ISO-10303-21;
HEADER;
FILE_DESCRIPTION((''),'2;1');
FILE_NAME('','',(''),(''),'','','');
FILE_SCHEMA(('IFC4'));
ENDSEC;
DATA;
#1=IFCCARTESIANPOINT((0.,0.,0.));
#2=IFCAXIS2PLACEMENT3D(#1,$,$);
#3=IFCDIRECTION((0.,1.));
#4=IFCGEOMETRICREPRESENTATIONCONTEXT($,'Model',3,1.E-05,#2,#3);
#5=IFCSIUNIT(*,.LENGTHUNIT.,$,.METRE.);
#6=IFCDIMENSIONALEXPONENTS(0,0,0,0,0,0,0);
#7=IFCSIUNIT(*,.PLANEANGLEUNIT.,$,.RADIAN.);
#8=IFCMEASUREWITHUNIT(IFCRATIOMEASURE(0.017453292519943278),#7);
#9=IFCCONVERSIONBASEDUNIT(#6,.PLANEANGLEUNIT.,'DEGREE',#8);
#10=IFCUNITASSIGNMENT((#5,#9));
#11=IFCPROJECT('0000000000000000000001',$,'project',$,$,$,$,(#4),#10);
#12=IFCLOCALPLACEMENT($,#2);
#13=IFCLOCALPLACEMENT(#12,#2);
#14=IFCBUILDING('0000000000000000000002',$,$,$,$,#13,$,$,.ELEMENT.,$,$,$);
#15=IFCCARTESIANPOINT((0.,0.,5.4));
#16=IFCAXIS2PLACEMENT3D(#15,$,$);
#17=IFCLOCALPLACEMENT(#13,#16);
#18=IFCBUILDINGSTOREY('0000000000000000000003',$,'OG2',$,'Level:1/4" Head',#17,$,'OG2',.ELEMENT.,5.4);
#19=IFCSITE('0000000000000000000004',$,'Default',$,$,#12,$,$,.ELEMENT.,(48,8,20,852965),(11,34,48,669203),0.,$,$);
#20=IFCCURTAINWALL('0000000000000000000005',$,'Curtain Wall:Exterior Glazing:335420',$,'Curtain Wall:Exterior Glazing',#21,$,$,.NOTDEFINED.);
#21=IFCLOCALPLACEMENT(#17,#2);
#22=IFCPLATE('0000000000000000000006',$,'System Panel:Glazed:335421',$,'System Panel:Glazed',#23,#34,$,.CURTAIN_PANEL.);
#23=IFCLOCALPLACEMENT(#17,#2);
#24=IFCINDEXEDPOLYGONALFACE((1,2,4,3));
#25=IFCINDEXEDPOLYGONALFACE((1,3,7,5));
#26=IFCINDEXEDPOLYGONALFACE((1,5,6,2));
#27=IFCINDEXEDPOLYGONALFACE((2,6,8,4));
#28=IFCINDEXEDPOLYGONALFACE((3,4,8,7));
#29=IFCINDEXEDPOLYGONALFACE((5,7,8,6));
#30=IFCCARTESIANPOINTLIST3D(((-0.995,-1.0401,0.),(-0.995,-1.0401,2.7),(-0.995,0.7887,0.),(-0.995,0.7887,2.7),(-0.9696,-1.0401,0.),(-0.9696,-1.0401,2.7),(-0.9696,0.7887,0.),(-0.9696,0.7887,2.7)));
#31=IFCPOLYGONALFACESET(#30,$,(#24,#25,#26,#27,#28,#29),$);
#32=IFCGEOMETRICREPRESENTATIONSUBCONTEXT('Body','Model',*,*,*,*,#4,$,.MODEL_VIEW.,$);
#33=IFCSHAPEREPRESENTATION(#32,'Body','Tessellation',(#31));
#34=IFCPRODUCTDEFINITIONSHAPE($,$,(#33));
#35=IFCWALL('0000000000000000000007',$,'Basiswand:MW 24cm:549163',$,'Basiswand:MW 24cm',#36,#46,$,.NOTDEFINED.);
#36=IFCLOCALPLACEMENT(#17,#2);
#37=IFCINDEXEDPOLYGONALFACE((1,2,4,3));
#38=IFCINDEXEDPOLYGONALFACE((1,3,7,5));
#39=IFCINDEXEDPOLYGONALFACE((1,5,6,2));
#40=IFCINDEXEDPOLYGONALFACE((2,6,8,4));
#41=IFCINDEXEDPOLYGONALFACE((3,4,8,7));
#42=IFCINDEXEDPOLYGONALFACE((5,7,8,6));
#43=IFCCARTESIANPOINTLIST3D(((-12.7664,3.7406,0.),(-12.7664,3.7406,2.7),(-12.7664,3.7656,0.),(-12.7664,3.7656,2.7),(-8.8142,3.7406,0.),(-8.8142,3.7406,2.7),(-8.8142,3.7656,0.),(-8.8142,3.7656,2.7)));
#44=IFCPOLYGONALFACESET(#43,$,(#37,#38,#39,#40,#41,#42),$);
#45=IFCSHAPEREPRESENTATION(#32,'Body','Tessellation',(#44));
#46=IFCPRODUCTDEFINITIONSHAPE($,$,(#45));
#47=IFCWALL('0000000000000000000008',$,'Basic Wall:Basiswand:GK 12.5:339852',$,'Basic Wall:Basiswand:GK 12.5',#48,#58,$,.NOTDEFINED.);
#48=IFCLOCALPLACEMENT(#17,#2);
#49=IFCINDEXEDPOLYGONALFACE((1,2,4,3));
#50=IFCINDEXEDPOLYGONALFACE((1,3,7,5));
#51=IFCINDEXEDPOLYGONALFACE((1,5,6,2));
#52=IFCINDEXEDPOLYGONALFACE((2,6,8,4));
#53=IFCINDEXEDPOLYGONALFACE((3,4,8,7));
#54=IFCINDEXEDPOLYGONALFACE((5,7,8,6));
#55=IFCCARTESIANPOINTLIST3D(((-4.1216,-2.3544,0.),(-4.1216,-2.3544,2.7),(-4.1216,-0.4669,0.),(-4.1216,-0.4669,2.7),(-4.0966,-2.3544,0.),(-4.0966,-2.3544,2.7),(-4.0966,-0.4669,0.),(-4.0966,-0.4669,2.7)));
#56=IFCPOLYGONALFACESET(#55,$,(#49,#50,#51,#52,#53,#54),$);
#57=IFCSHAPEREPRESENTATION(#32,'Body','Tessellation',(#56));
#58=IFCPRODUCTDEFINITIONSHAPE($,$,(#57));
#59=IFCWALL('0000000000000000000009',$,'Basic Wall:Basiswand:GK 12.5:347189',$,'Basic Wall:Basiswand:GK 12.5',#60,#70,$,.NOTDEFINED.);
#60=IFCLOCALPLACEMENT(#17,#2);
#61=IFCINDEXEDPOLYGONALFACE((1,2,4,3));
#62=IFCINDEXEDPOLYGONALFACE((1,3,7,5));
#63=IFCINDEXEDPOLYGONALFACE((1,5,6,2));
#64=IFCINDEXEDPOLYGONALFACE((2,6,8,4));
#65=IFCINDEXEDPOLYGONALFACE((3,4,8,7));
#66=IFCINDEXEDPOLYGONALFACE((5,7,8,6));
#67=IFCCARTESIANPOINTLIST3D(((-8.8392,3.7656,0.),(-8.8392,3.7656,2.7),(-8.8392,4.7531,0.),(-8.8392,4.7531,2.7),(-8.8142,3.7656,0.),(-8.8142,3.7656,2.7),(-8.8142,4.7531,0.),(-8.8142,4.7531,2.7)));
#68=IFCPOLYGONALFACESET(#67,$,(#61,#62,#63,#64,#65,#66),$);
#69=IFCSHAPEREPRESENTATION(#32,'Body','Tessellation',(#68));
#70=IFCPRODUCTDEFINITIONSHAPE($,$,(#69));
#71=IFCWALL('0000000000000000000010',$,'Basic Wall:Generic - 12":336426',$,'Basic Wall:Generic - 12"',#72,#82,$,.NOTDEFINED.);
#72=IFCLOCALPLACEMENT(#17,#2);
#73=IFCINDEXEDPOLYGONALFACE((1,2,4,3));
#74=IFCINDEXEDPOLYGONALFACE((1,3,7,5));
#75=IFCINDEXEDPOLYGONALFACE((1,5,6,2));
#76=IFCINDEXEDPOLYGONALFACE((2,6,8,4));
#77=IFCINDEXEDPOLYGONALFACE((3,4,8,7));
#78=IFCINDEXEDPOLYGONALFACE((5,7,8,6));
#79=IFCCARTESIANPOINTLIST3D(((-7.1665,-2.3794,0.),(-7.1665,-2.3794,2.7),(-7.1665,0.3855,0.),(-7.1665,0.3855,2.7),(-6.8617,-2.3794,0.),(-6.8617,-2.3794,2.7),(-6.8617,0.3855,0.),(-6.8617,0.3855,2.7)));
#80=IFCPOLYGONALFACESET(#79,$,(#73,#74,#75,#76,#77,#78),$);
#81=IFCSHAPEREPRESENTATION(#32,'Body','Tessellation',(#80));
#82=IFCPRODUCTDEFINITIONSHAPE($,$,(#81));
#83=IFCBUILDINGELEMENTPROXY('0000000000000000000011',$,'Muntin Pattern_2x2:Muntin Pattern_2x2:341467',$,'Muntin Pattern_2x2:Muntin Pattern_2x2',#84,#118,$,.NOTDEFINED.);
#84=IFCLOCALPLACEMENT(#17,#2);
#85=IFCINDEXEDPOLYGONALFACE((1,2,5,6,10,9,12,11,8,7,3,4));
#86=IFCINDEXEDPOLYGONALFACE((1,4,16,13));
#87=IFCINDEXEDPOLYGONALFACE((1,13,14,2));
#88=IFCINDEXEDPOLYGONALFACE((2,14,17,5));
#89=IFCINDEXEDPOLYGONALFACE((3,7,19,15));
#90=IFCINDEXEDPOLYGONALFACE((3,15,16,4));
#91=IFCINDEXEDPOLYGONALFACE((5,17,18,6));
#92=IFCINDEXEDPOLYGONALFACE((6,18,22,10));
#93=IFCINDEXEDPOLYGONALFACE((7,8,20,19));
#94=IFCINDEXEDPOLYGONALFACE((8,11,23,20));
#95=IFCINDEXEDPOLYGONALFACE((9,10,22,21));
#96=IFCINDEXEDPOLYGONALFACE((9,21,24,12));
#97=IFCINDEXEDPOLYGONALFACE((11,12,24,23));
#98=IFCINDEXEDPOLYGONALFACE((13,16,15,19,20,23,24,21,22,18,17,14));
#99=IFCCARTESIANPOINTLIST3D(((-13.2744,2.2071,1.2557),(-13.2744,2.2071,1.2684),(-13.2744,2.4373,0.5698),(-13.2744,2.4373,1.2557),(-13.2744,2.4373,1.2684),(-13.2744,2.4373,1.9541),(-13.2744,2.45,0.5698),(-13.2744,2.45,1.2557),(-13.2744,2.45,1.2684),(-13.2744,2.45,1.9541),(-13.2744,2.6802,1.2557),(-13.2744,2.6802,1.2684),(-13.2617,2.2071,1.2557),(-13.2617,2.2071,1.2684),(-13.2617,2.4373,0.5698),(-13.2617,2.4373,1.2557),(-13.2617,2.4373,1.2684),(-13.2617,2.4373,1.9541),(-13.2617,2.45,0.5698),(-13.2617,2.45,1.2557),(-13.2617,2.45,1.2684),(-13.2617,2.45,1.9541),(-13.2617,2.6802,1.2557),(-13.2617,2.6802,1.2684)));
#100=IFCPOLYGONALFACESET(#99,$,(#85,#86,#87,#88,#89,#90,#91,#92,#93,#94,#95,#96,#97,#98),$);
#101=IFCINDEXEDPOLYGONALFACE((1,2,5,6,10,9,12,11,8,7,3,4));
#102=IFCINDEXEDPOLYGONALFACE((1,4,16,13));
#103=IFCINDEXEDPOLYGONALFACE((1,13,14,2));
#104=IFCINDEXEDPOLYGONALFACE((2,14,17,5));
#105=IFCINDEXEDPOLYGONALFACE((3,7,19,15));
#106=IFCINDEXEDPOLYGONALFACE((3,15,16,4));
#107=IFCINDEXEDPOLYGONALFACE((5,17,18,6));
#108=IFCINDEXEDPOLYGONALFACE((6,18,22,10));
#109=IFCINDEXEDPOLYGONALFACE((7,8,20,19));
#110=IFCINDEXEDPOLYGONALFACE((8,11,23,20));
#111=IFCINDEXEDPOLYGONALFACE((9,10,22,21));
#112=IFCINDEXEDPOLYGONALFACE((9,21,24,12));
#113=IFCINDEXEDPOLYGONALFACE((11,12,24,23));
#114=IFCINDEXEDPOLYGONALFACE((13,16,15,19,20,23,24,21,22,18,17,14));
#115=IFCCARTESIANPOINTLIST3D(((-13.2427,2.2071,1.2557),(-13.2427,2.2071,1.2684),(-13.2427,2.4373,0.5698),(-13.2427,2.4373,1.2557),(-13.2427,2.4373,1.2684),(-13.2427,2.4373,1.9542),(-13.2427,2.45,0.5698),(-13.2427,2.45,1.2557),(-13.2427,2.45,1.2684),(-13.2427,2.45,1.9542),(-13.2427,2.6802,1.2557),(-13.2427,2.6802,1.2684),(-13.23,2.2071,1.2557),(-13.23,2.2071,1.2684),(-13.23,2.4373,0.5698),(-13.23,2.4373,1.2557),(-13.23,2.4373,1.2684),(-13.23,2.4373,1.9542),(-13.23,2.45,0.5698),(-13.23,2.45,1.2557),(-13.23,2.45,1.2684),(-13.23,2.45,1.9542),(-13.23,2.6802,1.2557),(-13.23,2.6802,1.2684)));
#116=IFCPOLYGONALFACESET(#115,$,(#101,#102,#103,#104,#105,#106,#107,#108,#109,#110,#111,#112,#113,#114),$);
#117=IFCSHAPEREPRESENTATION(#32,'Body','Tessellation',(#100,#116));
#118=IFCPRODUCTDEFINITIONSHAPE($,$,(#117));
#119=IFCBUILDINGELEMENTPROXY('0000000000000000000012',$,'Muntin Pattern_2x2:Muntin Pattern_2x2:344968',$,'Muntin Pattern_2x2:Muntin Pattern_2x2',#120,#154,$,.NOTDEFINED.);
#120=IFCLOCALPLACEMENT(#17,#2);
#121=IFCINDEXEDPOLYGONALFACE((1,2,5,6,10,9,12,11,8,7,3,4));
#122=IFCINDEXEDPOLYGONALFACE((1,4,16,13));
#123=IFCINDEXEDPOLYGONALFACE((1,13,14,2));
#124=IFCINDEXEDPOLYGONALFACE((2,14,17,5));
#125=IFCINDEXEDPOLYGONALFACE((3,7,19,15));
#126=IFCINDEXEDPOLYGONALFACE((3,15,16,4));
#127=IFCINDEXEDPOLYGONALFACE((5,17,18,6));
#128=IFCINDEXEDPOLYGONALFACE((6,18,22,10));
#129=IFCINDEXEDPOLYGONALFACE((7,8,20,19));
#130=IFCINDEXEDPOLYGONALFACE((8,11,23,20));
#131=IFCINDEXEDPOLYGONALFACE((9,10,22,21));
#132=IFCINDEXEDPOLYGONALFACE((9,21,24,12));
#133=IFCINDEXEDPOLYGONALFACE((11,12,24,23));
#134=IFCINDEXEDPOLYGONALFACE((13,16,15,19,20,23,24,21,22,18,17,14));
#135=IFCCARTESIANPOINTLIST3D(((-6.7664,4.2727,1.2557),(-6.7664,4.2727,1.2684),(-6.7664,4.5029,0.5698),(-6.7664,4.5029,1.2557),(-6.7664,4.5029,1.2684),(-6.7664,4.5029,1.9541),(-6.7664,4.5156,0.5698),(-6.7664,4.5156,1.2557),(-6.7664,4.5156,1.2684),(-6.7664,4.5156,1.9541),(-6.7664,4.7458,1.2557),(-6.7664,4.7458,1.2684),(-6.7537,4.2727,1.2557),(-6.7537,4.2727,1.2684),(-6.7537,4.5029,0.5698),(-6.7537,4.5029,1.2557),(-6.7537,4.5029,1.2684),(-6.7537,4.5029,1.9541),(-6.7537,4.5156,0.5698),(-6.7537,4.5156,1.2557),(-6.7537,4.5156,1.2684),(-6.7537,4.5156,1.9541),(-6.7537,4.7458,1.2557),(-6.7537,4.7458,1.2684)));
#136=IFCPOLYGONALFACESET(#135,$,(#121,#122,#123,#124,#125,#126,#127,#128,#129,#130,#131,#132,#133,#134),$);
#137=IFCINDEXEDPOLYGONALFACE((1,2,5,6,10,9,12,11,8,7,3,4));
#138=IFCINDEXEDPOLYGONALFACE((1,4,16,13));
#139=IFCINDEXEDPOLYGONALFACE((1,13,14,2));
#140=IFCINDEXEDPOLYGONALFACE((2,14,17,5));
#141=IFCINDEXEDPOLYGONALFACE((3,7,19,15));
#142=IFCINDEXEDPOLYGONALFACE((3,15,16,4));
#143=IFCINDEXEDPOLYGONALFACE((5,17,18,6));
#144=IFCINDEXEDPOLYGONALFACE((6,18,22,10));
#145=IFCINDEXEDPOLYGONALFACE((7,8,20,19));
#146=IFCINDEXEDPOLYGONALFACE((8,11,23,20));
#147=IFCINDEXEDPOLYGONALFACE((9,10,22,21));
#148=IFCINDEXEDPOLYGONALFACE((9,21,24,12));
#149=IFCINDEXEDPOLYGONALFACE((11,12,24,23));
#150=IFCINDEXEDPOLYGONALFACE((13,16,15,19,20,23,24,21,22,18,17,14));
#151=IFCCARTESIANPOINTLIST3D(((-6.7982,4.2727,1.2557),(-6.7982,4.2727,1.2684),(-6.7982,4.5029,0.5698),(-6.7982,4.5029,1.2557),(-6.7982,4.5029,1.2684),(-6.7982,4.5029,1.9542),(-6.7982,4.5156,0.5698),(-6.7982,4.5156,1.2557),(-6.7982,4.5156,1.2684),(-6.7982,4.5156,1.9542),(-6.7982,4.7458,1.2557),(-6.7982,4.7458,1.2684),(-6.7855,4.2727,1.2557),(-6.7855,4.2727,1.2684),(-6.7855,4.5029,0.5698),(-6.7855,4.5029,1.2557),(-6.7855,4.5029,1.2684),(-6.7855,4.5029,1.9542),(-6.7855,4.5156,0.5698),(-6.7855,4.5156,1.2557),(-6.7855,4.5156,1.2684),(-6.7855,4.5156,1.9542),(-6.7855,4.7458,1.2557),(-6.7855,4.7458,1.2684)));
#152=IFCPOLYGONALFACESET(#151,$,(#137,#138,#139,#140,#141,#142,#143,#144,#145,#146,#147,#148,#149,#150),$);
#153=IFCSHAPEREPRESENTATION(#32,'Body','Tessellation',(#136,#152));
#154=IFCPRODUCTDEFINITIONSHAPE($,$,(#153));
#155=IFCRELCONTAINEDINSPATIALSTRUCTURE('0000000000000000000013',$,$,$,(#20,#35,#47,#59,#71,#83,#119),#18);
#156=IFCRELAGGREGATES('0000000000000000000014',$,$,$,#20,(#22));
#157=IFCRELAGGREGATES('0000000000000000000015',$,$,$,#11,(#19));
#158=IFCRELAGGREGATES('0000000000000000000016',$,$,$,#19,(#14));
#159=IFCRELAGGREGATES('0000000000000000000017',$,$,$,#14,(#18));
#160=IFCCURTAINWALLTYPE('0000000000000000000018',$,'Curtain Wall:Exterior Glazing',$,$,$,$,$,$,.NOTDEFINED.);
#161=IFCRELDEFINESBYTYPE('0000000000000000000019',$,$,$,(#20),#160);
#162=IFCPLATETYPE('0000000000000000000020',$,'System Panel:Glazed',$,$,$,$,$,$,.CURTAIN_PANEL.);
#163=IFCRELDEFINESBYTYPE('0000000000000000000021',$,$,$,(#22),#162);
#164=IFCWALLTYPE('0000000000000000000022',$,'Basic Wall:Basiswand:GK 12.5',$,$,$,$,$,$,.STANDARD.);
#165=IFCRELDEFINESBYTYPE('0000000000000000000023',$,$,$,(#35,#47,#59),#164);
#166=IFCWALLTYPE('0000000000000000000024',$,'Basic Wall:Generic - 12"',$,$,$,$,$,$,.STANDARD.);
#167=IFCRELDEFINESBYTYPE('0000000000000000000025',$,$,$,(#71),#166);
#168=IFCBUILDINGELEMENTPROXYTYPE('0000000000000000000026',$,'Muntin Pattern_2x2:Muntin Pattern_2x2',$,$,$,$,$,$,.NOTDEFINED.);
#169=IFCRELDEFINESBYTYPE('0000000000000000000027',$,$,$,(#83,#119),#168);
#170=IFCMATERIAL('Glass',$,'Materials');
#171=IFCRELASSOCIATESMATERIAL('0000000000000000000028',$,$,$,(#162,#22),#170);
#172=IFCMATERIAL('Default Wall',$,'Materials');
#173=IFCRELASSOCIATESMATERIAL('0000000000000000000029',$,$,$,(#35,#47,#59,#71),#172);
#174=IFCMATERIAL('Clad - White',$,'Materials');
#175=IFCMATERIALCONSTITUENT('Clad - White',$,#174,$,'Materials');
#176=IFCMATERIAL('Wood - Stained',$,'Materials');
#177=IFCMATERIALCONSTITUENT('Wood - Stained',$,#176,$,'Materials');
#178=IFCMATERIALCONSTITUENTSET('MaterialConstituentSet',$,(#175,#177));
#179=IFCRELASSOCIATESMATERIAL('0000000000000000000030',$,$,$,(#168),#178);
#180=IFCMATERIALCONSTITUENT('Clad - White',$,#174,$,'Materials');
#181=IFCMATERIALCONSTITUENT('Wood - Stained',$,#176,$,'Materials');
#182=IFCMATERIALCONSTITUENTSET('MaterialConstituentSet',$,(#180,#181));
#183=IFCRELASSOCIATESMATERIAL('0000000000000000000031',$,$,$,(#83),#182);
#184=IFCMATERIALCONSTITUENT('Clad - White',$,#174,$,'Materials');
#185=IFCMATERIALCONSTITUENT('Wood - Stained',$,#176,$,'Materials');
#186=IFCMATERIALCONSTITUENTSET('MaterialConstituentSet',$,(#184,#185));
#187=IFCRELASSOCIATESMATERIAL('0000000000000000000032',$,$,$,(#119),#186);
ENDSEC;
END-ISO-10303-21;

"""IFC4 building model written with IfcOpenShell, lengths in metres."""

from ifc_helpers import new_model, entity, si_unit, converted_unit, direction, frame, origin, place, context, subcontext, project, spatial, indexed_curve, outline, extrude, source, transform, mapped, material, constituent, constituent_set, type_object, type_shapes, element, aggregate, save


model = new_model("IFC4")

# Units and contexts
model_context = context("Model", 3, precision=1e-05, world=origin(), true_north=direction((0.0, 1.0)))
body_context = subcontext(model_context, "Body", "Model", "MODEL_VIEW")
ifc_project = project(units=[si_unit("LENGTHUNIT", "METRE"), converted_unit("PLANEANGLEUNIT", "DEGREE", entity("IfcRatioMeasure", 0.017453292519943278), si_unit("PLANEANGLEUNIT", "RADIAN"), dimensions=[0, 0, 0, 0, 0, 0, 0])], contexts=[model_context])

# Site, building, storey
site_placement = place(None, origin())
site = spatial("IfcSite", under=ifc_project, at=site_placement, Name="Default", CompositionType="ELEMENT", RefLatitude=(48, 8, 20, 852965), RefLongitude=(11, 34, 48, 669203), RefElevation=0.0)
building_placement = place(site_placement, origin())
building = spatial("IfcBuilding", under=site, at=building_placement, CompositionType="ELEMENT")
storey_placement = place(building_placement, frame((0.0, 0.0, 5.4)))
storey = spatial("IfcBuildingStorey", under=building, at=storey_placement, Name="OG2", ObjectType="Level:1/4\" Head", LongName="OG2", CompositionType="ELEMENT", Elevation=5.4)

# Curtain wall, plate
curtain_wall_type = type_object("IfcCurtainWallType", Name="Curtain Wall:Exterior Glazing", PredefinedType="NOTDEFINED")
curtain_wall_placement = place(storey_placement, frame((0.0, 0.0, -5.4)))
curtain_wall = element("IfcCurtainWall", 1, at=curtain_wall_placement, inside=storey, type_object=curtain_wall_type, Name="Curtain Wall:Exterior Glazing:335420", ObjectType="Curtain Wall:Exterior Glazing", PredefinedType="NOTDEFINED")
ifc_material_1 = material(Name="Glass", Category="Materials")
plate_type = type_object("IfcPlateType", Name="System Panel:Glazed", PredefinedType="CURTAIN_PANEL", material=ifc_material_1)
shared_shape_1 = source(origin(), body_context, "Body", "SweptSolid", [
    extrude(outline(indexed_curve([(-0.0127, -0.9144), (0.0127, -0.9144), (0.0127, 0.9144), (-0.0127, 0.9144), (-0.0127, -0.9144)], self_intersect=False)), frame((0.0, 0.0317, 0.0), z_axis=(0.0, 0.0, 1.0), x_axis=(0.0, 1.0, 0.0)), (0.0, 0.0, 1.0), 2.7),
])
type_shapes(plate_type, [shared_shape_1])
plate_placement = place(curtain_wall_placement, frame((-1.0141, -0.1257, 5.4), z_axis=(0.0, 0.0, 1.0), x_axis=(0.0, -1.0, 0.0)))
plate = element("IfcPlate", 2, at=plate_placement, type_object=plate_type, material=ifc_material_1, Name="System Panel:Glazed:335421", ObjectType="System Panel:Glazed", PredefinedType="CURTAIN_PANEL", context=body_context, shape_type="MappedRepresentation", body=[
    mapped(shared_shape_1, transform((0.0, 0.0, 0.0), scale=1.0)),
])
aggregate(curtain_wall, [plate])

# Walls
ifc_material_2 = material(Name="Default Wall", Category="Materials")
wall_type_1 = type_object("IfcWallType", Name="Basic Wall:Basiswand:GK 12.5", PredefinedType="STANDARD")
wall_1_placement = place(storey_placement, frame((-8.8142, 3.7531, 0.0), z_axis=(0.0, 0.0, 1.0), x_axis=(-1.0, 0.0, 0.0)))
element("IfcWall", 3, at=wall_1_placement, inside=storey, type_object=wall_type_1, material=ifc_material_2, Name="Basiswand:MW 24cm:549163", ObjectType="Basiswand:MW 24cm", PredefinedType="NOTDEFINED", context=body_context, shape_type="SweptSolid", body=[
    extrude(outline(indexed_curve([(3.9522, 0.0125), (0.0, 0.0125), (0.0, -0.0125), (3.9522, -0.0125), (3.9522, 0.0125)], self_intersect=False)), origin(), (0.0, 0.0, 1.0), 2.7),
])
wall_2_placement = place(storey_placement, frame((-4.1091, -0.4669, 0.0), z_axis=(0.0, 0.0, 1.0), x_axis=(0.0, -1.0, 0.0)))
element("IfcWall", 4, at=wall_2_placement, inside=storey, type_object=wall_type_1, material=ifc_material_2, Name="Basic Wall:Basiswand:GK 12.5:339852", ObjectType="Basic Wall:Basiswand:GK 12.5", PredefinedType="NOTDEFINED", context=body_context, shape_type="SweptSolid", body=[
    extrude(outline(indexed_curve([(1.8875, 0.0125), (0.0, 0.0125), (0.0, -0.0125), (1.8875, -0.0125), (1.8875, 0.0125)], self_intersect=False)), origin(), (0.0, 0.0, 1.0), 2.7),
])
wall_3_placement = place(storey_placement, frame((-8.8267, 4.7531, 0.0), z_axis=(0.0, 0.0, 1.0), x_axis=(0.0, -1.0, 0.0)))
element("IfcWall", 5, at=wall_3_placement, inside=storey, type_object=wall_type_1, material=ifc_material_2, Name="Basic Wall:Basiswand:GK 12.5:347189", ObjectType="Basic Wall:Basiswand:GK 12.5", PredefinedType="NOTDEFINED", context=body_context, shape_type="SweptSolid", body=[
    extrude(outline(indexed_curve([(0.9875, 0.0125), (0.0, 0.0125), (0.0, -0.0125), (0.9875, -0.0125), (0.9875, 0.0125)], self_intersect=False)), origin(), (0.0, 0.0, 1.0), 2.7),
])
wall_type_2 = type_object("IfcWallType", Name="Basic Wall:Generic - 12\"", PredefinedType="STANDARD")
wall_4_placement = place(storey_placement, frame((-7.0141, 0.3855, 0.0), z_axis=(0.0, 0.0, 1.0), x_axis=(0.0, -1.0, 0.0)))
element("IfcWall", 6, at=wall_4_placement, inside=storey, type_object=wall_type_2, material=ifc_material_2, Name="Basic Wall:Generic - 12\":336426", ObjectType="Basic Wall:Generic - 12\"", PredefinedType="NOTDEFINED", context=body_context, shape_type="SweptSolid", body=[
    extrude(outline(indexed_curve([(2.7649, 0.1524), (0.0, 0.1524), (0.0, -0.1524), (2.7649, -0.1524), (2.7649, 0.1524)], self_intersect=False)), origin(), (0.0, 0.0, 1.0), 2.7),
])

# Building element proxies
ifc_material_3 = material(Name="Clad - White", Category="Materials")
ifc_constituent_1 = constituent(ifc_material_3, Name="Clad - White", Category="Materials")
ifc_material_4 = material(Name="Wood - Stained", Category="Materials")
ifc_constituent_2 = constituent(ifc_material_4, Name="Wood - Stained", Category="Materials")
ifc_constituent_set_1 = constituent_set(constituents=[ifc_constituent_1, ifc_constituent_2], Name="MaterialConstituentSet")
ifc_constituent_3 = constituent(ifc_material_3, Name="Clad - White", Category="Materials")
ifc_constituent_4 = constituent(ifc_material_4, Name="Wood - Stained", Category="Materials")
ifc_constituent_set_2 = constituent_set(constituents=[ifc_constituent_3, ifc_constituent_4], Name="MaterialConstituentSet")
building_element_proxy_type_1 = type_object("IfcBuildingElementProxyType", Name="Muntin Pattern_2x2:Muntin Pattern_2x2", PredefinedType="NOTDEFINED", material=ifc_constituent_set_2)
shared_shape_2 = source(origin(), body_context, "Body", "SweptSolid", [
    extrude(outline(indexed_curve([(0.0064, -0.0064), (0.6921, -0.0064), (0.6921, 0.0063), (0.0064, 0.0063), (0.0064, 0.2365), (-0.0063, 0.2365), (-0.0063, 0.0063), (-0.6922, 0.0063), (-0.6922, -0.0064), (-0.0063, -0.0064), (-0.0063, -0.2365), (0.0064, -0.2365), (0.0064, -0.0064)], self_intersect=False)), frame((0.0, -0.0222, 0.6921), z_axis=(0.0, 1.0, 0.0), x_axis=(0.0, 0.0, 1.0)), (0.0, 0.0, 1.0), 0.0127),
    extrude(outline(indexed_curve([(0.0064, -0.0064), (0.6922, -0.0064), (0.6922, 0.0063), (0.0064, 0.0063), (0.0064, 0.2365), (-0.0063, 0.2365), (-0.0063, 0.0063), (-0.6922, 0.0063), (-0.6922, -0.0064), (-0.0063, -0.0064), (-0.0063, -0.2365), (0.0064, -0.2365), (0.0064, -0.0064)], self_intersect=False)), frame((0.0, 0.0095, 0.6922), z_axis=(0.0, 1.0, 0.0), x_axis=(0.0, 0.0, 1.0)), (0.0, 0.0, 1.0), 0.0127),
])
type_shapes(building_element_proxy_type_1, [shared_shape_2])
proxy_1_placement = place(storey_placement, frame((-13.2522, 2.4437, 0.5699), z_axis=(0.0, 0.0, 1.0), x_axis=(0.0, -1.0, 0.0)))
element("IfcBuildingElementProxy", 7, at=proxy_1_placement, inside=storey, type_object=building_element_proxy_type_1, material=ifc_constituent_set_1, Name="Muntin Pattern_2x2:Muntin Pattern_2x2:341467", ObjectType="Muntin Pattern_2x2:Muntin Pattern_2x2", PredefinedType="NOTDEFINED", context=body_context, shape_type="MappedRepresentation", body=[
    mapped(shared_shape_2, transform((0.0, 0.0, 0.0), scale=1.0)),
])
ifc_constituent_5 = constituent(ifc_material_3, Name="Clad - White", Category="Materials")
ifc_constituent_6 = constituent(ifc_material_4, Name="Wood - Stained", Category="Materials")
ifc_constituent_set_3 = constituent_set(constituents=[ifc_constituent_5, ifc_constituent_6], Name="MaterialConstituentSet")
proxy_2_placement = place(storey_placement, frame((-6.7759, 4.5093, 0.5699), z_axis=(0.0, 0.0, 1.0), x_axis=(0.0, 1.0, 0.0)))
element("IfcBuildingElementProxy", 8, at=proxy_2_placement, inside=storey, type_object=building_element_proxy_type_1, material=ifc_constituent_set_3, Name="Muntin Pattern_2x2:Muntin Pattern_2x2:344968", ObjectType="Muntin Pattern_2x2:Muntin Pattern_2x2", PredefinedType="NOTDEFINED", context=body_context, shape_type="MappedRepresentation", body=[
    mapped(shared_shape_2, transform((0.0, 0.0, 0.0), scale=1.0)),
])

save(model, "model.ifc")
